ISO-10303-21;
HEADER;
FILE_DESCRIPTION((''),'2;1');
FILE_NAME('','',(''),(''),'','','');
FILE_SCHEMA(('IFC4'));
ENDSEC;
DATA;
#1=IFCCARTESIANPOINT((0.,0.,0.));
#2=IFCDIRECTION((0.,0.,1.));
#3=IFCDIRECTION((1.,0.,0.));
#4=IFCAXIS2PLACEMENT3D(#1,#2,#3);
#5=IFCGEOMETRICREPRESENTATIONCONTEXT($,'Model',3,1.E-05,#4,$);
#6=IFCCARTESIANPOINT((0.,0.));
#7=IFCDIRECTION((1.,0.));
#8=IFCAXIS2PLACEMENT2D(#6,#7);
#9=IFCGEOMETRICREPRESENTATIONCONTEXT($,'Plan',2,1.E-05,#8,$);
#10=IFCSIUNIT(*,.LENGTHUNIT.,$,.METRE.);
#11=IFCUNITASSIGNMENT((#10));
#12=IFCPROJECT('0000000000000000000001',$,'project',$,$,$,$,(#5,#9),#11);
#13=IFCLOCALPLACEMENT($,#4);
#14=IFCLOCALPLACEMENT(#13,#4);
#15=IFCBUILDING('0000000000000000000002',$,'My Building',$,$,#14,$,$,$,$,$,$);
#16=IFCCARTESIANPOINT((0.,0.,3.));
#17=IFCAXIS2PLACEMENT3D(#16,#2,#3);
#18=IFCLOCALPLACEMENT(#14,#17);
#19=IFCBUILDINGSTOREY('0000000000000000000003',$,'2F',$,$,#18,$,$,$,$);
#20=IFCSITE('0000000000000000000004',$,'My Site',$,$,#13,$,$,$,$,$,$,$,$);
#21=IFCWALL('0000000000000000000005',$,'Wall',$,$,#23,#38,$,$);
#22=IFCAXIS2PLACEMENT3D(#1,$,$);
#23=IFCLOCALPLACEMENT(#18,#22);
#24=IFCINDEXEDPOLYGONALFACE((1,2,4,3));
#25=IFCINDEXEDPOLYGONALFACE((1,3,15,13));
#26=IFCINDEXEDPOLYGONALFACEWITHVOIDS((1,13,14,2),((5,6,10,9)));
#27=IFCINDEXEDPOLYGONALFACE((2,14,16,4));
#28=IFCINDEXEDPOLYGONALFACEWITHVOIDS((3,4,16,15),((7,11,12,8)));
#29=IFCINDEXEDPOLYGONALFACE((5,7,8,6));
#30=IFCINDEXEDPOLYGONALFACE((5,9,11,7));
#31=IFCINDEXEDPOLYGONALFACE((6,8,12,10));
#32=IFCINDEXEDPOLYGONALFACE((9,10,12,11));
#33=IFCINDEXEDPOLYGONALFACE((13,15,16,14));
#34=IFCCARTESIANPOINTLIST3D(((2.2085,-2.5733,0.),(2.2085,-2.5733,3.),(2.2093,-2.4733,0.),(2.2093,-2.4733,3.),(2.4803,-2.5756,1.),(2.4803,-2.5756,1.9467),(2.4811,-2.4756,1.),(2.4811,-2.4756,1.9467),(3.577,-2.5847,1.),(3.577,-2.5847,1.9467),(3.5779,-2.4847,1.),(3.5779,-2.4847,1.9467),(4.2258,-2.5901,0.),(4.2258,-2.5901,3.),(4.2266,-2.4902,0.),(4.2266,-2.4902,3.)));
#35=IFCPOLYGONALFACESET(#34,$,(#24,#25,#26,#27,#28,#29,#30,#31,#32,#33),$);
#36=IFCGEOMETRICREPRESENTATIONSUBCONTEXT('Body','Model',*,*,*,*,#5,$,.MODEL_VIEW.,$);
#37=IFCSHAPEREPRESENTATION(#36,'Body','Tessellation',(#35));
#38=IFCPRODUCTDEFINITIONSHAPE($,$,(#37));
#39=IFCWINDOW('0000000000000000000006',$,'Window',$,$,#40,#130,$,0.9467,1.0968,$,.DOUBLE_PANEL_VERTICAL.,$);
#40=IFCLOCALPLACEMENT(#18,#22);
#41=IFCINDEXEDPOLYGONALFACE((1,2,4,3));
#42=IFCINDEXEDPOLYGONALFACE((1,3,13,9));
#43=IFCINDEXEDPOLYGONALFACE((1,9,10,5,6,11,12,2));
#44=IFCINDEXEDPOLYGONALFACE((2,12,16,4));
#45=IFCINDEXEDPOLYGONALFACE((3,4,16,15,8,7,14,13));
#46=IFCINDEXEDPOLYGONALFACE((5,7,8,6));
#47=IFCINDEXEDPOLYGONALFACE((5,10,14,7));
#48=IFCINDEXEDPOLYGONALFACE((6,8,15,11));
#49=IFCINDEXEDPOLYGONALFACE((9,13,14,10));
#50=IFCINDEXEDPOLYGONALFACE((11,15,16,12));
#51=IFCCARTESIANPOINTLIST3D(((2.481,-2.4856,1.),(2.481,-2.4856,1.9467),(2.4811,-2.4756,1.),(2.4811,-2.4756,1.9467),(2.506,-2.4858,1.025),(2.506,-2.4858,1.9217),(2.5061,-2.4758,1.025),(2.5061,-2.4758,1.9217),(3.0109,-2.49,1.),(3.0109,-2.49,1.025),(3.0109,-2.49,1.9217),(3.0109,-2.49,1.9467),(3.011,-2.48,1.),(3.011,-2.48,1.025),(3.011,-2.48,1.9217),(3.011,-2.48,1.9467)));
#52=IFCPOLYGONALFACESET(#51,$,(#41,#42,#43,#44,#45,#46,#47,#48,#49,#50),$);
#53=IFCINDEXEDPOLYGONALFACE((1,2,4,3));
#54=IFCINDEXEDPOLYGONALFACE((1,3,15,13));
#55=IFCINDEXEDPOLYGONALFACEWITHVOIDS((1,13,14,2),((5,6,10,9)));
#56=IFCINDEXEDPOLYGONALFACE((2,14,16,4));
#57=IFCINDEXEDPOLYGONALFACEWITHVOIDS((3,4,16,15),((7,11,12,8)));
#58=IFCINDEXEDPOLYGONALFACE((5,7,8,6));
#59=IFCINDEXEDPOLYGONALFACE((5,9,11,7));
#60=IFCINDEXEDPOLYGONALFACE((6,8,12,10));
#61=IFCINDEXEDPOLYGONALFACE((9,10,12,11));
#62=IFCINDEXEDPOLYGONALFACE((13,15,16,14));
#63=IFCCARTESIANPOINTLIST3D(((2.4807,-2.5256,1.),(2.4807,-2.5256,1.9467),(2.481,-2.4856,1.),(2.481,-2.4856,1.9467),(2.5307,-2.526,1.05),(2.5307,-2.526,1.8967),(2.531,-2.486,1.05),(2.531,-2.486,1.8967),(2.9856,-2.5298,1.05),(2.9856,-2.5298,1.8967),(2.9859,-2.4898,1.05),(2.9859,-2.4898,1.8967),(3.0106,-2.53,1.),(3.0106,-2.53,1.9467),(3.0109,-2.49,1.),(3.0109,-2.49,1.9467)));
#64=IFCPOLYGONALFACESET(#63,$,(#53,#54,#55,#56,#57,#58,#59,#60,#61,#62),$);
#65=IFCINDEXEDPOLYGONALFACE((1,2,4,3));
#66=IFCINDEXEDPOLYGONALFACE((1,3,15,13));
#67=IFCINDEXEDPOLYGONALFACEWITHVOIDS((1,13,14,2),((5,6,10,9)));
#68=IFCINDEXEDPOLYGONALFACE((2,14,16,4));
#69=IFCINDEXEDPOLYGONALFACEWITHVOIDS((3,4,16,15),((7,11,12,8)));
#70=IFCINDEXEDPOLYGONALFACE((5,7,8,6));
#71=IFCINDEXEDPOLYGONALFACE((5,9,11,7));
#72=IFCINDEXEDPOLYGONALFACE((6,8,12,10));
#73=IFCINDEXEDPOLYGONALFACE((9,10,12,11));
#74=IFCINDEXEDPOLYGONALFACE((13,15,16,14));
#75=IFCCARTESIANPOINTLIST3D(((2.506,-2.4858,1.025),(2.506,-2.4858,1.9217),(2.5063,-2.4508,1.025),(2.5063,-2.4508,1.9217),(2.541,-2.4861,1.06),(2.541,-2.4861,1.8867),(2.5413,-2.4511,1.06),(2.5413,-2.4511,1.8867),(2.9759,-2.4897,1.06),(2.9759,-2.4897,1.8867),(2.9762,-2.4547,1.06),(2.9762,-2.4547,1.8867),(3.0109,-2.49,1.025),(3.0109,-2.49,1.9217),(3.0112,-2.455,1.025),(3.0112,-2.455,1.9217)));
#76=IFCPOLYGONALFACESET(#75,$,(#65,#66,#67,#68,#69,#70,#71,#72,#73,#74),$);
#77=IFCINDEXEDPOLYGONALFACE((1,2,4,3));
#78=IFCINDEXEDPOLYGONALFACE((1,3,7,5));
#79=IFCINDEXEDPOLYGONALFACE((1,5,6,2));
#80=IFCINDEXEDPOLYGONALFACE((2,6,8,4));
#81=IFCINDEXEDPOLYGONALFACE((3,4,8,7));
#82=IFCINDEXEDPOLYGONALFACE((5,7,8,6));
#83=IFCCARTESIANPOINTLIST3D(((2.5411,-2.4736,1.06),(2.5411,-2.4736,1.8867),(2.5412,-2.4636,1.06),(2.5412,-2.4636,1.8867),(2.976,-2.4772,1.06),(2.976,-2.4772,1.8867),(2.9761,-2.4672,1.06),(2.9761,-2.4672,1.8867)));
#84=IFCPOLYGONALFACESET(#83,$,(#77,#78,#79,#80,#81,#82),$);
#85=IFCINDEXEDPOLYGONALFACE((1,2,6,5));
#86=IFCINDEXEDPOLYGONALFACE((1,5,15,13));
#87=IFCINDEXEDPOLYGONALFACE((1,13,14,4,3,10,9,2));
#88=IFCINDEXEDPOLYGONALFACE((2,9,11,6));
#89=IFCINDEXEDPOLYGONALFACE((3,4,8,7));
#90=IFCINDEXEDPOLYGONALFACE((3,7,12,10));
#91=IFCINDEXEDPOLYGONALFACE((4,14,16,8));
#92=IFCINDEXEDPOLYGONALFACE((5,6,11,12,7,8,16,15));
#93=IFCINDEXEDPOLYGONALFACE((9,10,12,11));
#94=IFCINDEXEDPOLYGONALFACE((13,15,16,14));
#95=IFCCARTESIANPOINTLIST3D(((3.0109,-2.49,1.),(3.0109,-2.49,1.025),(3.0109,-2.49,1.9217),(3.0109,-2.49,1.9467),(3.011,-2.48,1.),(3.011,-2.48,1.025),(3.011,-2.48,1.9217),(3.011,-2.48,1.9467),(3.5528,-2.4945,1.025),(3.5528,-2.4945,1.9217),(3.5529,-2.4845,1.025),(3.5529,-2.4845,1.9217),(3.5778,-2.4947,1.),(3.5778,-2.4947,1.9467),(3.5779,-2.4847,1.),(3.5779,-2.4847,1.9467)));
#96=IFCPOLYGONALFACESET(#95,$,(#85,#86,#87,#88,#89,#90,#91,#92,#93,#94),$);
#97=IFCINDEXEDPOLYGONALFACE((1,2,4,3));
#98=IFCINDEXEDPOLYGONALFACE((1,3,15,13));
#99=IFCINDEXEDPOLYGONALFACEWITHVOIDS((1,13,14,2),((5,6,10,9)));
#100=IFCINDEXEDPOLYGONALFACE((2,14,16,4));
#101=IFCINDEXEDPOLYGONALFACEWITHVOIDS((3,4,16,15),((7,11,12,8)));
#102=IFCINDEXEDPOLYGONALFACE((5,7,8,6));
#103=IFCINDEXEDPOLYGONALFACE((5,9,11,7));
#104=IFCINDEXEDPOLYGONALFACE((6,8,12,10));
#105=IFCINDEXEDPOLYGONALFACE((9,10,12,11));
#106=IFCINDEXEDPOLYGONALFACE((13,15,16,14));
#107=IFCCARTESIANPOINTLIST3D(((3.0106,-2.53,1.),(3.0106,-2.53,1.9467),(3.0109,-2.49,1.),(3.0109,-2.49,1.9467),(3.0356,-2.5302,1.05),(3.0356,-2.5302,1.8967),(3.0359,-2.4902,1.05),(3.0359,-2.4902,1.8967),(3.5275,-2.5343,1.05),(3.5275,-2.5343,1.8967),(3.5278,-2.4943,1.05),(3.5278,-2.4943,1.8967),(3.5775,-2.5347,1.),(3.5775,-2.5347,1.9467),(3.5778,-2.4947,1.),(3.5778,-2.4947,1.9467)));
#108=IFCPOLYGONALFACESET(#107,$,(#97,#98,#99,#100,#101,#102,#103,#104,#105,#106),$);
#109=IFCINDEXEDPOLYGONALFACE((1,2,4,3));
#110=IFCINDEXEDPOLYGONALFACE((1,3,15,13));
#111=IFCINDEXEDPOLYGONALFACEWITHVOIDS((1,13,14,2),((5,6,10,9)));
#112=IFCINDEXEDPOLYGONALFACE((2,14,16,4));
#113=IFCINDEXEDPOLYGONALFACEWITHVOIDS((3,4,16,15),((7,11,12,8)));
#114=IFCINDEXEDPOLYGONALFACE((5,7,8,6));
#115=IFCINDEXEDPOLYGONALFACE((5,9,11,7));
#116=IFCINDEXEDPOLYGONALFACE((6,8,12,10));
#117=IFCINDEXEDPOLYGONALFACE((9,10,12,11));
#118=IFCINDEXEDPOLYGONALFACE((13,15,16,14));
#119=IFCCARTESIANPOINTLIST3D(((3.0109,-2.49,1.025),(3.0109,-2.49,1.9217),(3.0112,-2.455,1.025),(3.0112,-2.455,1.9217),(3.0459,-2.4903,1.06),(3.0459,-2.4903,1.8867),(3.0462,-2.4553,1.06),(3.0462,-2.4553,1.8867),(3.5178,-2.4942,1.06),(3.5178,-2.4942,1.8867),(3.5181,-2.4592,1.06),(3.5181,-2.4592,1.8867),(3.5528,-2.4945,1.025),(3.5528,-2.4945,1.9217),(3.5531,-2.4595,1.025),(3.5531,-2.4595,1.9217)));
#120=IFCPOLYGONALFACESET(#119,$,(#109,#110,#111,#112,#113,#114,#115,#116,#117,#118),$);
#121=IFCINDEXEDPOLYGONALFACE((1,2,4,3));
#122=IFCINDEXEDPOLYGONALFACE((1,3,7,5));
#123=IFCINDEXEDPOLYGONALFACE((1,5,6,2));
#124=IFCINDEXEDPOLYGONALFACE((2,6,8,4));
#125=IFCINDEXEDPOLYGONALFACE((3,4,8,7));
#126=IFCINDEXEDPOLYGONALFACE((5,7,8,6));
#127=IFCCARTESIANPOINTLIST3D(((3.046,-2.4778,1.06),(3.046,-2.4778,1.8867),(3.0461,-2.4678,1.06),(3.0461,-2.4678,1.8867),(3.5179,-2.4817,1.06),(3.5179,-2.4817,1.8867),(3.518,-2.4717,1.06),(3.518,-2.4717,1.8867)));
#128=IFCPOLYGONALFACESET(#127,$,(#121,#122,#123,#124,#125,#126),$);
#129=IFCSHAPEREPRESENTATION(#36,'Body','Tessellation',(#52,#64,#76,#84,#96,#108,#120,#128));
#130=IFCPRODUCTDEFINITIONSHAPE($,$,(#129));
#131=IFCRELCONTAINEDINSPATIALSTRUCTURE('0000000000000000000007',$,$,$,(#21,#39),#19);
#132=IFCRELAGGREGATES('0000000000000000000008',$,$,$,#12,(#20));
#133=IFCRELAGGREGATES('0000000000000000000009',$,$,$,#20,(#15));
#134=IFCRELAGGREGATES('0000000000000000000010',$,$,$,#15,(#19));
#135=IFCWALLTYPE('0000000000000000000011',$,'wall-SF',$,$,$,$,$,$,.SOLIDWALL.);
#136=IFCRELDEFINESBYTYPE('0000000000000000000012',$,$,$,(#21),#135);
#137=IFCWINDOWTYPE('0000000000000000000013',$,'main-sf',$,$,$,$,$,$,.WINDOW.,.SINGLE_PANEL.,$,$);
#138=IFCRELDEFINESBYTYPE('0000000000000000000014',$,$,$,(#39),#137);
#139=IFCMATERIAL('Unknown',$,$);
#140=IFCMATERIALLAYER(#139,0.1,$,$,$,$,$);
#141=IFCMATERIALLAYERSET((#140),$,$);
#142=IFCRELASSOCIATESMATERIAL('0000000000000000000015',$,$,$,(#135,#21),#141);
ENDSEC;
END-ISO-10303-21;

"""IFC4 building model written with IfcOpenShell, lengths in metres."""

from ifc_helpers import new_model, entity, si_unit, frame, origin_with_axes, origin_2d_with_axis, place, context, subcontext, project, spatial, line, indexed_curve, outline, extrude, shape, source, transform, mapped, material, layer, layer_set, layer_usage, type_object, type_shapes, element, fill, save


model = new_model("IFC4")

# Units and contexts
model_context = context("Model", 3, precision=1e-05, world=origin_with_axes())
plan_context = context("Plan", 2, precision=1e-05, world=origin_2d_with_axis())
body_context_1 = subcontext(model_context, "Body", "Model", "MODEL_VIEW")
body_context_2 = subcontext(plan_context, "Body", "Plan", "PLAN_VIEW")
ifc_project = project(units=[si_unit("LENGTHUNIT", "METRE")], contexts=[model_context, plan_context])

# Site, building, storey
site_placement = place(None, origin_with_axes())
site = spatial("IfcSite", under=ifc_project, at=site_placement, Name="My Site")
building_placement = place(site_placement, origin_with_axes())
building = spatial("IfcBuilding", under=site, at=building_placement, Name="My Building")
storey_placement = place(building_placement, frame((0.0, 0.0, 3.0), z_axis=(0.0, 0.0, 1.0), x_axis=(1.0, 0.0, 0.0)))
storey = spatial("IfcBuildingStorey", under=building, at=storey_placement, Name="2F")

# Shared definitions
ifc_material = material(Name="Unknown")

# Shared definitions
ifc_layer_1 = layer(ifc_material, 0.1)
ifc_layer_set_1 = layer_set([ifc_layer_1])
wall_type = type_object("IfcWallType", Name="wall-SF", PredefinedType="SOLIDWALL", material=ifc_layer_set_1)

# Wall, opening, window
ifc_layer_usage_1 = layer_usage(ifc_layer_set_1, "AXIS2", "POSITIVE", 0.0)
wall_1_placement = place(storey_placement, frame((4.2266, -2.4902, 0.0), z_axis=(0.0, 0.0, 1.0), x_axis=(-0.999965, 0.00834, 0.0)))
wall_1 = element("IfcWall", 1, at=wall_1_placement, inside=storey, type_object=wall_type, material=ifc_layer_usage_1, Name="Wall", context=body_context_1, shape_type="SweptSolid", body=[
    extrude(outline(indexed_curve([(0.0, 0.0), (0.0, 0.1), (2.0173, 0.1), (2.0173, 0.0)], segments=[line(1, 2, 3, 4, 1)])), origin_with_axes(), (0.0, 0.0, 1.0), 3.0),
])
shared_shape_1 = source(origin_with_axes(), body_context_1, "Body", "SweptSolid", [
    extrude(outline(indexed_curve([(0.0, 0.0), (1.0968, 0.0), (1.0968, 0.9467), (0.0, 0.9467)], segments=[line(1, 2, 3, 4, 1)])), frame((0.0, -0.6, 0.0), z_axis=(0.0, -1.0, 0.0), x_axis=(1.0, 0.0, 0.0)), (0.0, 0.0, -1.0), 1.2),
])
opening_1_placement = place(wall_1_placement, frame((1.7455, 0.1, 1.0), z_axis=(0.0, 0.0, 1.0), x_axis=(-1.0, 0.0, 0.0)))
opening_1 = element("IfcOpeningElement", 2, at=opening_1_placement, cuts=wall_1, PredefinedType="OPENING", context=body_context_1, shape_type="MappedRepresentation", body=[
    mapped(shared_shape_1, transform((0.0, 0.0, 0.0), x_axis=(1.0, 0.0, 0.0), y_axis=(0.0, 1.0, 0.0), z_axis=(0.0, 0.0, 1.0), scale=1.0)),
])
window_type_1 = type_object("IfcWindowType", Name="main-sf", PartitioningType="SINGLE_PANEL", PredefinedType="WINDOW")
shared_shape_2 = source(origin_with_axes(), body_context_1, "Body", "SweptSolid", [
    extrude(outline(indexed_curve([(0.5299, 0.0), (0.0, 0.0), (0.0, 0.9467), (0.5299, 0.9467), (0.5299, 0.9217), (0.025, 0.9217), (0.025, 0.025), (0.5299, 0.025)], segments=[line(1, 2, 3, 4, 5, 6, 7, 8, 1)])), frame((0.0, 0.09, 0.0), z_axis=(0.0, -1.0, 0.0), x_axis=(1.0, 0.0, 0.0)), (0.0, 0.0, -1.0), 0.01),
    extrude(outline(indexed_curve([(0.0, 0.0), (0.5299, 0.0), (0.5299, 0.9467), (0.0, 0.9467)], segments=[line(1, 2, 3, 4, 1)]), holes=[indexed_curve([(0.05, 0.05), (0.5049, 0.05), (0.5049, 0.8967), (0.05, 0.8967)], segments=[line(1, 2, 3, 4, 1)])]), frame((0.0, 0.05, 0.0), z_axis=(0.0, -1.0, 0.0), x_axis=(1.0, 0.0, 0.0)), (0.0, 0.0, -1.0), 0.04),
    extrude(outline(indexed_curve([(0.0, 0.0), (0.5049, 0.0), (0.5049, 0.8967), (0.0, 0.8967)], segments=[line(1, 2, 3, 4, 1)]), holes=[indexed_curve([(0.035, 0.035), (0.4699, 0.035), (0.4699, 0.8617), (0.035, 0.8617)], segments=[line(1, 2, 3, 4, 1)])]), frame((0.025, 0.09, 0.025), z_axis=(0.0, -1.0, 0.0), x_axis=(1.0, 0.0, 0.0)), (0.0, 0.0, -1.0), 0.035),
    extrude(outline(indexed_curve([(0.035, 0.035), (0.4699, 0.035), (0.4699, 0.8617), (0.035, 0.8617)], segments=[line(1, 2, 3, 4, 1)])), frame((0.025, 0.1025, 0.025), z_axis=(0.0, -1.0, 0.0), x_axis=(1.0, 0.0, 0.0)), (0.0, 0.0, -1.0), 0.01),
    extrude(outline(indexed_curve([(0.0, 0.9467), (0.5669, 0.9467), (0.5669, 0.0), (0.0, 0.0), (0.0, 0.025), (0.5419, 0.025), (0.5419, 0.9217), (0.0, 0.9217)], segments=[line(1, 2, 3, 4, 5, 6, 7, 8, 1)])), frame((0.5299, 0.09, 0.0), z_axis=(0.0, -1.0, 0.0), x_axis=(1.0, 0.0, 0.0)), (0.0, 0.0, -1.0), 0.01),
    extrude(outline(indexed_curve([(0.0, 0.0), (0.5669, 0.0), (0.5669, 0.9467), (0.0, 0.9467)], segments=[line(1, 2, 3, 4, 1)]), holes=[indexed_curve([(0.025, 0.05), (0.5169, 0.05), (0.5169, 0.8967), (0.025, 0.8967)], segments=[line(1, 2, 3, 4, 1)])]), frame((0.5299, 0.05, 0.0), z_axis=(0.0, -1.0, 0.0), x_axis=(1.0, 0.0, 0.0)), (0.0, 0.0, -1.0), 0.04),
    extrude(outline(indexed_curve([(0.0, 0.0), (0.5419, 0.0), (0.5419, 0.8967), (0.0, 0.8967)], segments=[line(1, 2, 3, 4, 1)]), holes=[indexed_curve([(0.035, 0.035), (0.5069, 0.035), (0.5069, 0.8617), (0.035, 0.8617)], segments=[line(1, 2, 3, 4, 1)])]), frame((0.5299, 0.09, 0.025), z_axis=(0.0, -1.0, 0.0), x_axis=(1.0, 0.0, 0.0)), (0.0, 0.0, -1.0), 0.035),
    extrude(outline(indexed_curve([(0.035, 0.035), (0.5069, 0.035), (0.5069, 0.8617), (0.035, 0.8617)], segments=[line(1, 2, 3, 4, 1)])), frame((0.5299, 0.1025, 0.025), z_axis=(0.0, -1.0, 0.0), x_axis=(1.0, 0.0, 0.0)), (0.0, 0.0, -1.0), 0.01),
])
shared_shape_3 = source(origin_with_axes(), body_context_2, "Body", "Curve2D", [
    entity("IfcIndexedPolyCurve", entity("IfcCartesianPointList2D", [[0.05, 0.05], [0.5049, 0.05]])),
    entity("IfcIndexedPolyCurve", entity("IfcCartesianPointList2D", [[0.0, 0.1], [0.025, 0.1], [0.025, 0.09], [0.05, 0.09], [0.05, 0.05], [0.0, 0.05]]), [entity("IfcLineIndex", [1, 2, 3, 4, 5, 6, 1])]),
    entity("IfcIndexedPolyCurve", entity("IfcCartesianPointList2D", [[0.5299, 0.1], [0.5299, 0.1], [0.5299, 0.09], [0.5049, 0.09], [0.5049, 0.05], [0.5299, 0.05]])),
    entity("IfcIndexedPolyCurve", entity("IfcCartesianPointList2D", [[0.025, 0.09], [0.06, 0.09], [0.06, 0.125], [0.025, 0.125]]), [entity("IfcLineIndex", [1, 2, 3, 4, 1])]),
    entity("IfcIndexedPolyCurve", entity("IfcCartesianPointList2D", [[0.5299, 0.09], [0.4949, 0.09], [0.4949, 0.125], [0.5299, 0.125]]), [entity("IfcLineIndex", [1, 2, 3, 4, 1])]),
    entity("IfcIndexedPolyCurve", entity("IfcCartesianPointList2D", [[0.06, 0.09], [0.4949, 0.09]])),
    entity("IfcIndexedPolyCurve", entity("IfcCartesianPointList2D", [[0.06, 0.125], [0.4949, 0.125]])),
    entity("IfcIndexedPolyCurve", entity("IfcCartesianPointList2D", [[0.06, 0.1075], [0.4949, 0.1075]])),
    entity("IfcIndexedPolyCurve", entity("IfcCartesianPointList2D", [[0.5549, 0.05], [1.0468, 0.05]])),
    entity("IfcIndexedPolyCurve", entity("IfcCartesianPointList2D", [[0.5299, 0.1], [0.5299, 0.1], [0.5299, 0.09], [0.5549, 0.09], [0.5549, 0.05], [0.5299, 0.05]])),
    entity("IfcIndexedPolyCurve", entity("IfcCartesianPointList2D", [[1.0968, 0.1], [1.0718, 0.1], [1.0718, 0.09], [1.0468, 0.09], [1.0468, 0.05], [1.0968, 0.05]]), [entity("IfcLineIndex", [1, 2, 3, 4, 5, 6, 1])]),
    entity("IfcIndexedPolyCurve", entity("IfcCartesianPointList2D", [[0.5299, 0.09], [0.5649, 0.09], [0.5649, 0.125], [0.5299, 0.125]]), [entity("IfcLineIndex", [1, 2, 3, 4, 1])]),
    entity("IfcIndexedPolyCurve", entity("IfcCartesianPointList2D", [[1.0718, 0.09], [1.0368, 0.09], [1.0368, 0.125], [1.0718, 0.125]]), [entity("IfcLineIndex", [1, 2, 3, 4, 1])]),
    entity("IfcIndexedPolyCurve", entity("IfcCartesianPointList2D", [[0.5649, 0.09], [1.0368, 0.09]])),
    entity("IfcIndexedPolyCurve", entity("IfcCartesianPointList2D", [[0.5649, 0.125], [1.0368, 0.125]])),
    entity("IfcIndexedPolyCurve", entity("IfcCartesianPointList2D", [[0.5649, 0.1075], [1.0368, 0.1075]])),
])
type_shapes(window_type_1, [shared_shape_2, shared_shape_3])
window_1_placement = place(opening_1_placement, origin_with_axes())
window_1 = element("IfcWindow", 3, at=window_1_placement, inside=storey, type_object=window_type_1, Name="Window", OverallHeight=0.9467, OverallWidth=1.0968, PartitioningType="DOUBLE_PANEL_VERTICAL", shapes=[
    shape(body_context_1, "Body", "MappedRepresentation", [mapped(shared_shape_2, transform((0.0, 0.0, 0.0), x_axis=(1.0, 0.0, 0.0), y_axis=(0.0, 1.0, 0.0), z_axis=(0.0, 0.0, 1.0), scale=1.0))]),
    shape(body_context_2, "Body", "MappedRepresentation", [mapped(shared_shape_3, transform((0.0, 0.0, 0.0), x_axis=(1.0, 0.0, 0.0), y_axis=(0.0, 1.0, 0.0), z_axis=(0.0, 0.0, 1.0), scale=1.0))]),
])
fill(opening_1, window_1)

save(model, "model.ifc")
